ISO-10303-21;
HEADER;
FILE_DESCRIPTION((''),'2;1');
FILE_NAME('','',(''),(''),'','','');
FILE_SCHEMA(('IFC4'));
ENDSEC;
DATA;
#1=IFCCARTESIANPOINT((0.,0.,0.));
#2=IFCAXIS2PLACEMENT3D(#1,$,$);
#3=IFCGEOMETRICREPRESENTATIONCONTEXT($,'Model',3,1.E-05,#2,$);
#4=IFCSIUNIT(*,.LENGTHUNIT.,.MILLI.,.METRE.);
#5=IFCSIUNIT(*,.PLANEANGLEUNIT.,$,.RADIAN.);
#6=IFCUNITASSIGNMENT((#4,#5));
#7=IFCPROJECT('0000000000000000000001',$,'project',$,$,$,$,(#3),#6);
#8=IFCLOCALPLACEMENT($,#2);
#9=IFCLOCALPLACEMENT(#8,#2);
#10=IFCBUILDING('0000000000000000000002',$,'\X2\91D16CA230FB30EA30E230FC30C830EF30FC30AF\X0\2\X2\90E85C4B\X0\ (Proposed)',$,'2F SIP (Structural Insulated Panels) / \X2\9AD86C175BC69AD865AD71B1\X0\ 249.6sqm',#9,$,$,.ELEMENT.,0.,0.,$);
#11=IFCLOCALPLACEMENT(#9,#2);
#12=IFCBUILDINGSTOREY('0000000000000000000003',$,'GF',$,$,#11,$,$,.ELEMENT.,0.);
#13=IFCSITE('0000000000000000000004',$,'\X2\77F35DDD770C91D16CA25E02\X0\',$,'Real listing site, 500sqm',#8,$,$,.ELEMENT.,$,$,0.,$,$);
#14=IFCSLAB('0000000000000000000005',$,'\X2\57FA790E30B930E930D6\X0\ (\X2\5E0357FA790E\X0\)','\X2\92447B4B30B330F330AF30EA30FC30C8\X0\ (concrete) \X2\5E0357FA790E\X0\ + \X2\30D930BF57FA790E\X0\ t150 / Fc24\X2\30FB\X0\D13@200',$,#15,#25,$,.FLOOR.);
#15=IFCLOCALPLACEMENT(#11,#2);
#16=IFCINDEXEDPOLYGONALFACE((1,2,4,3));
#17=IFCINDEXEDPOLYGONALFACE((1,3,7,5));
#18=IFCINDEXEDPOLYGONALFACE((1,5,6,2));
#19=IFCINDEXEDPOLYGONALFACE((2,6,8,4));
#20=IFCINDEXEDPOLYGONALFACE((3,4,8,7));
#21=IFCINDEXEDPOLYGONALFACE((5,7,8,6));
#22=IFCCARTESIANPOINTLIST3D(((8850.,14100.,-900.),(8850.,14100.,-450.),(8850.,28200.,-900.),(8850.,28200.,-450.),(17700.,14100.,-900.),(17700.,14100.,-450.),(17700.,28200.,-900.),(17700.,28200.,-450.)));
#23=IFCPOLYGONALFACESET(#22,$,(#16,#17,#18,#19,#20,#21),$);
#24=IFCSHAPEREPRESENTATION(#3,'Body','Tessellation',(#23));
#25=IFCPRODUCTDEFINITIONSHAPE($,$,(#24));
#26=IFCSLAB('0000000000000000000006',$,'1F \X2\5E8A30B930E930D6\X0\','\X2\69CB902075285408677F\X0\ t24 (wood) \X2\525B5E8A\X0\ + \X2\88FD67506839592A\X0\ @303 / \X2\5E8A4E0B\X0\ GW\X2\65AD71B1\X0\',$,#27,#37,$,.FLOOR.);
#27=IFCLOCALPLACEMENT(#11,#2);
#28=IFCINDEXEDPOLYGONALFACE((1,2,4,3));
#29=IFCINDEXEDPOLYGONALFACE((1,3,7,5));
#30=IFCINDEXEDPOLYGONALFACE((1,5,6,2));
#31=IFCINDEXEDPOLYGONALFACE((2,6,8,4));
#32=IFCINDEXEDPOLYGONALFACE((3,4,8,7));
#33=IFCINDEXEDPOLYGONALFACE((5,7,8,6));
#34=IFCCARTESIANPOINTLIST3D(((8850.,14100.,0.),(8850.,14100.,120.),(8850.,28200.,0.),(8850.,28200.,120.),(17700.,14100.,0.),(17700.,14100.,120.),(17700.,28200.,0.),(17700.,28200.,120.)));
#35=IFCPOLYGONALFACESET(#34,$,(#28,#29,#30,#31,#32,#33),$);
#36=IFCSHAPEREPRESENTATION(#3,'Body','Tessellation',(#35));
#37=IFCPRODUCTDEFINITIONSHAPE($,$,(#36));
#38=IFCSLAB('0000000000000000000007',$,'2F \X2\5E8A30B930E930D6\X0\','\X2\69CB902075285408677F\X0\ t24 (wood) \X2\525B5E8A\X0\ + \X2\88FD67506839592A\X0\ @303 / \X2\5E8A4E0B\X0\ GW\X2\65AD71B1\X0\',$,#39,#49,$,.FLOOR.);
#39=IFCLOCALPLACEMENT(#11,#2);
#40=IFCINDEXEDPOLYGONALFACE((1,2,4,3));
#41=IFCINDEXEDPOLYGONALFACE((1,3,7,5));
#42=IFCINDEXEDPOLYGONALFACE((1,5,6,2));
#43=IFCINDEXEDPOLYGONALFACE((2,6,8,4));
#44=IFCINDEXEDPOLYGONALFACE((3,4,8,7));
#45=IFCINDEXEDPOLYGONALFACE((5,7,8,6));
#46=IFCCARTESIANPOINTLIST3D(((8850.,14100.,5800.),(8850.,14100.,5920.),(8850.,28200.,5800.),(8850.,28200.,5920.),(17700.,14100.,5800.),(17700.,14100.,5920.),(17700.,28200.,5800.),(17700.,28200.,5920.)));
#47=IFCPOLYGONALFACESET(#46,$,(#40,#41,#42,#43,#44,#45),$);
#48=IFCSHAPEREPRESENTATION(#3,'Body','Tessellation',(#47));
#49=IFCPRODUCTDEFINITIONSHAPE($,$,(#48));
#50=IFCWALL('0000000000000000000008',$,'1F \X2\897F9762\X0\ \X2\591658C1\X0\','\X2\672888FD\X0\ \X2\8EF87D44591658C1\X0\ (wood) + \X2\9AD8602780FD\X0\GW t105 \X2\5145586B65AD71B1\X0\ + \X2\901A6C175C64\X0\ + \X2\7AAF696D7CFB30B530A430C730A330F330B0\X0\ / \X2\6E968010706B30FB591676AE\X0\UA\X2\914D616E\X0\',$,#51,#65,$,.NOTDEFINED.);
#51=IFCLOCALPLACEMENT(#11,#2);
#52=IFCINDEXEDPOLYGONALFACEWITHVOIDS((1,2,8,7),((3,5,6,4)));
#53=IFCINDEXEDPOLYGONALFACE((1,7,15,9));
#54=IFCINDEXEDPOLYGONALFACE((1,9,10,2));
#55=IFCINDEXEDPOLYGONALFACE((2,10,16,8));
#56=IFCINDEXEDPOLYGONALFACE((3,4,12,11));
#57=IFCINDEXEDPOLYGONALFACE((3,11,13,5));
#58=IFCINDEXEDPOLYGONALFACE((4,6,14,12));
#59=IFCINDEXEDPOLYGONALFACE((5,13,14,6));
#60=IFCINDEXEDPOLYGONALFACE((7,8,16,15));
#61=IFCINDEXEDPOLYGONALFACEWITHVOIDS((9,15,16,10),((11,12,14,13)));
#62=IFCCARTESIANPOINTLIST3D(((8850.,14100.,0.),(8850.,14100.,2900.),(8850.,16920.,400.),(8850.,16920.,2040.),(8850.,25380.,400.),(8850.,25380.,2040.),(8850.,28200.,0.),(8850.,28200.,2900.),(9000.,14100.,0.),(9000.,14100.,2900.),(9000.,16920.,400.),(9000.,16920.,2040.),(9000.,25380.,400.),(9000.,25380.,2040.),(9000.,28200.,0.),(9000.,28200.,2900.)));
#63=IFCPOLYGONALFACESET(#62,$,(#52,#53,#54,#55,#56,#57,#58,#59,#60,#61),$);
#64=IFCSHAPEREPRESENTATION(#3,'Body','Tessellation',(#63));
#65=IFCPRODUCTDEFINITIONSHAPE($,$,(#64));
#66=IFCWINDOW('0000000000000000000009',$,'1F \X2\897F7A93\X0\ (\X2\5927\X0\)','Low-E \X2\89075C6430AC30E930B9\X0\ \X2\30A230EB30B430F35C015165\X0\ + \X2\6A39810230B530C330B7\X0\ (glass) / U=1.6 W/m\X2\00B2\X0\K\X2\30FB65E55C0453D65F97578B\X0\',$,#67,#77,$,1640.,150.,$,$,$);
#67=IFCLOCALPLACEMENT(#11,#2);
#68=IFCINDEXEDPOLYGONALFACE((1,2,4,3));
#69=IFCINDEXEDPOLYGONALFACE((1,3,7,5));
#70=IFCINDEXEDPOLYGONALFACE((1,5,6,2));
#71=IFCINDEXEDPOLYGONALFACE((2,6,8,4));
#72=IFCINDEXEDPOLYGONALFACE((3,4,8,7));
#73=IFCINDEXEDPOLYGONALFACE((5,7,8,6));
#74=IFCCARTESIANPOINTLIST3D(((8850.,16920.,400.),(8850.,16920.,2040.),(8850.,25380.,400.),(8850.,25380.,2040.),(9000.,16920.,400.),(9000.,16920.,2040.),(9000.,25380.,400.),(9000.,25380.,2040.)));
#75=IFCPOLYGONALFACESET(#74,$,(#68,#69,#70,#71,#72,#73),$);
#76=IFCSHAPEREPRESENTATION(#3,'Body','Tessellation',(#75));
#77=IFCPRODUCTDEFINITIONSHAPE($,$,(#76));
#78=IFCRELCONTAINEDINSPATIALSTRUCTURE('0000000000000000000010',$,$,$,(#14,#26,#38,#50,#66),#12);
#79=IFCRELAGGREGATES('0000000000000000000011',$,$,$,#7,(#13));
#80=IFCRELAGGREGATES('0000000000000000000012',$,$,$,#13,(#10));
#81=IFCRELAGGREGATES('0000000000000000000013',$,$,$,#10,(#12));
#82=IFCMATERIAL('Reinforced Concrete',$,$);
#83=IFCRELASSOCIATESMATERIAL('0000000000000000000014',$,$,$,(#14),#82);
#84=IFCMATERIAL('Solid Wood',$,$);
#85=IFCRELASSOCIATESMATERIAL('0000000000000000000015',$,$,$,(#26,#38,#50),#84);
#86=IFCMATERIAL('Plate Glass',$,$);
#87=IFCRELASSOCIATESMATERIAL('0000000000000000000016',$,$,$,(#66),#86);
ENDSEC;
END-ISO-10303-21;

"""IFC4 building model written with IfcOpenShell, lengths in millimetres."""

from ifc_helpers import new_model, si_unit, frame, frame_2d, origin, place, context, project, spatial, rectangle, extrude, material, element, fill, save


model = new_model("IFC4")

# Units and contexts
model_context = context("Model", 3, precision=1e-05, world=origin())
ifc_project = project(units=[si_unit("LENGTHUNIT", "METRE", prefix="MILLI"), si_unit("PLANEANGLEUNIT", "RADIAN")], contexts=[model_context])

# Site, building, storey
site_placement = place(None, origin())
site = spatial("IfcSite", under=ifc_project, at=site_placement, Name="石川県金沢市", ObjectType="Real listing site, 500sqm", CompositionType="ELEMENT", RefElevation=0.0)
building_placement = place(site_placement, origin())
building = spatial("IfcBuilding", under=site, at=building_placement, Name="金沢・リモートワーク2部屋 (Proposed)", ObjectType="2F SIP (Structural Insulated Panels) / 高気密高断熱 249.6sqm", CompositionType="ELEMENT", ElevationOfRefHeight=0.0, ElevationOfTerrain=0.0)
storey_placement = place(building_placement, origin())
storey = spatial("IfcBuildingStorey", under=building, at=storey_placement, Name="GF", CompositionType="ELEMENT", Elevation=0.0)

# Shared definitions
ifc_material_1 = material(Name="Solid Wood")

# Slabs
ifc_material_2 = material(Name="Reinforced Concrete")
slab_1_placement = place(storey_placement, frame((4425.0, 7050.0, -450.0)))
element("IfcSlab", 1, at=slab_1_placement, inside=storey, material=ifc_material_2, Name="基礎スラブ (布基礎)", Description="鉄筋コンクリート (concrete) 布基礎 + ベタ基礎 t150 / Fc24・D13@200", PredefinedType="FLOOR", context=model_context, shape_type="SweptSolid", body=[
    extrude(rectangle(XDim=8850.0, YDim=14100.0, at=frame_2d((4425.0, 7050.0))), frame((4425.0, 7050.0, -450.0)), (0.0, 0.0, 1.0), 450.0),
])
slab_2_placement = place(storey_placement, frame((4425.0, 7050.0, 0.0)))
element("IfcSlab", 2, at=slab_2_placement, inside=storey, material=ifc_material_1, Name="1F 床スラブ", Description="構造用合板 t24 (wood) 剛床 + 製材根太 @303 / 床下 GW断熱", PredefinedType="FLOOR", context=model_context, shape_type="SweptSolid", body=[
    extrude(rectangle(XDim=8850.0, YDim=14100.0, at=frame_2d((4425.0, 7050.0))), frame((4425.0, 7050.0, 0.0)), (0.0, 0.0, 1.0), 120.0),
])
slab_3_placement = place(storey_placement, frame((4425.0, 7050.0, 2900.0)))
element("IfcSlab", 3, at=slab_3_placement, inside=storey, material=ifc_material_1, Name="2F 床スラブ", Description="構造用合板 t24 (wood) 剛床 + 製材根太 @303 / 床下 GW断熱", PredefinedType="FLOOR", context=model_context, shape_type="SweptSolid", body=[
    extrude(rectangle(XDim=8850.0, YDim=14100.0, at=frame_2d((4425.0, 7050.0))), frame((4425.0, 7050.0, 2900.0)), (0.0, 0.0, 1.0), 120.0),
])

# Shared definitions
ifc_material_3 = material(Name="Plate Glass")

# Wall, opening, window
wall_1_placement = place(storey_placement, frame((4425.0, 7050.0, 0.0)))
wall_1 = element("IfcWall", 4, at=wall_1_placement, inside=storey, material=ifc_material_1, Name="1F 西面 外壁", Description="木製 軸組外壁 (wood) + 高性能GW t105 充填断熱 + 通気層 + 窯業系サイディング / 準耐火・外皮UA配慮", PredefinedType="NOTDEFINED", context=model_context, shape_type="SweptSolid", body=[
    extrude(rectangle(XDim=150.0, YDim=14100.0, at=frame_2d((75.0, 7050.0))), frame((4425.0, 7050.0, 0.0)), (0.0, 0.0, 1.0), 2900.0),
])
opening_1_placement = place(storey_placement, frame((4425.0, 8460.0, 200.0)))
opening_1 = element("IfcOpeningElement", 5, at=opening_1_placement, cuts=wall_1, PredefinedType="NOTDEFINED", context=model_context, shape_type="SweptSolid", body=[
    extrude(rectangle(XDim=150.0, YDim=8460.0, at=frame_2d((75.0, 4230.0))), frame((4425.0, 8460.0, 200.0)), (0.0, 0.0, 1.0), 1640.0),
])
window_1_placement = place(storey_placement, frame((4425.0, 8460.0, 200.0)))
window_1 = element("IfcWindow", 6, at=window_1_placement, inside=storey, material=ifc_material_3, Name="1F 西窓 (大)", Description="Low-E 複層ガラス アルゴン封入 + 樹脂サッシ (glass) / U=1.6 W/m²K・日射取得型", OverallHeight=1640.0, OverallWidth=150.0, context=model_context, shape_type="SweptSolid", body=[
    extrude(rectangle(XDim=150.0, YDim=8460.0, at=frame_2d((75.0, 4230.0))), frame((4425.0, 8460.0, 200.0)), (0.0, 0.0, 1.0), 1640.0),
])
fill(opening_1, window_1)

save(model, "model.ifc")
